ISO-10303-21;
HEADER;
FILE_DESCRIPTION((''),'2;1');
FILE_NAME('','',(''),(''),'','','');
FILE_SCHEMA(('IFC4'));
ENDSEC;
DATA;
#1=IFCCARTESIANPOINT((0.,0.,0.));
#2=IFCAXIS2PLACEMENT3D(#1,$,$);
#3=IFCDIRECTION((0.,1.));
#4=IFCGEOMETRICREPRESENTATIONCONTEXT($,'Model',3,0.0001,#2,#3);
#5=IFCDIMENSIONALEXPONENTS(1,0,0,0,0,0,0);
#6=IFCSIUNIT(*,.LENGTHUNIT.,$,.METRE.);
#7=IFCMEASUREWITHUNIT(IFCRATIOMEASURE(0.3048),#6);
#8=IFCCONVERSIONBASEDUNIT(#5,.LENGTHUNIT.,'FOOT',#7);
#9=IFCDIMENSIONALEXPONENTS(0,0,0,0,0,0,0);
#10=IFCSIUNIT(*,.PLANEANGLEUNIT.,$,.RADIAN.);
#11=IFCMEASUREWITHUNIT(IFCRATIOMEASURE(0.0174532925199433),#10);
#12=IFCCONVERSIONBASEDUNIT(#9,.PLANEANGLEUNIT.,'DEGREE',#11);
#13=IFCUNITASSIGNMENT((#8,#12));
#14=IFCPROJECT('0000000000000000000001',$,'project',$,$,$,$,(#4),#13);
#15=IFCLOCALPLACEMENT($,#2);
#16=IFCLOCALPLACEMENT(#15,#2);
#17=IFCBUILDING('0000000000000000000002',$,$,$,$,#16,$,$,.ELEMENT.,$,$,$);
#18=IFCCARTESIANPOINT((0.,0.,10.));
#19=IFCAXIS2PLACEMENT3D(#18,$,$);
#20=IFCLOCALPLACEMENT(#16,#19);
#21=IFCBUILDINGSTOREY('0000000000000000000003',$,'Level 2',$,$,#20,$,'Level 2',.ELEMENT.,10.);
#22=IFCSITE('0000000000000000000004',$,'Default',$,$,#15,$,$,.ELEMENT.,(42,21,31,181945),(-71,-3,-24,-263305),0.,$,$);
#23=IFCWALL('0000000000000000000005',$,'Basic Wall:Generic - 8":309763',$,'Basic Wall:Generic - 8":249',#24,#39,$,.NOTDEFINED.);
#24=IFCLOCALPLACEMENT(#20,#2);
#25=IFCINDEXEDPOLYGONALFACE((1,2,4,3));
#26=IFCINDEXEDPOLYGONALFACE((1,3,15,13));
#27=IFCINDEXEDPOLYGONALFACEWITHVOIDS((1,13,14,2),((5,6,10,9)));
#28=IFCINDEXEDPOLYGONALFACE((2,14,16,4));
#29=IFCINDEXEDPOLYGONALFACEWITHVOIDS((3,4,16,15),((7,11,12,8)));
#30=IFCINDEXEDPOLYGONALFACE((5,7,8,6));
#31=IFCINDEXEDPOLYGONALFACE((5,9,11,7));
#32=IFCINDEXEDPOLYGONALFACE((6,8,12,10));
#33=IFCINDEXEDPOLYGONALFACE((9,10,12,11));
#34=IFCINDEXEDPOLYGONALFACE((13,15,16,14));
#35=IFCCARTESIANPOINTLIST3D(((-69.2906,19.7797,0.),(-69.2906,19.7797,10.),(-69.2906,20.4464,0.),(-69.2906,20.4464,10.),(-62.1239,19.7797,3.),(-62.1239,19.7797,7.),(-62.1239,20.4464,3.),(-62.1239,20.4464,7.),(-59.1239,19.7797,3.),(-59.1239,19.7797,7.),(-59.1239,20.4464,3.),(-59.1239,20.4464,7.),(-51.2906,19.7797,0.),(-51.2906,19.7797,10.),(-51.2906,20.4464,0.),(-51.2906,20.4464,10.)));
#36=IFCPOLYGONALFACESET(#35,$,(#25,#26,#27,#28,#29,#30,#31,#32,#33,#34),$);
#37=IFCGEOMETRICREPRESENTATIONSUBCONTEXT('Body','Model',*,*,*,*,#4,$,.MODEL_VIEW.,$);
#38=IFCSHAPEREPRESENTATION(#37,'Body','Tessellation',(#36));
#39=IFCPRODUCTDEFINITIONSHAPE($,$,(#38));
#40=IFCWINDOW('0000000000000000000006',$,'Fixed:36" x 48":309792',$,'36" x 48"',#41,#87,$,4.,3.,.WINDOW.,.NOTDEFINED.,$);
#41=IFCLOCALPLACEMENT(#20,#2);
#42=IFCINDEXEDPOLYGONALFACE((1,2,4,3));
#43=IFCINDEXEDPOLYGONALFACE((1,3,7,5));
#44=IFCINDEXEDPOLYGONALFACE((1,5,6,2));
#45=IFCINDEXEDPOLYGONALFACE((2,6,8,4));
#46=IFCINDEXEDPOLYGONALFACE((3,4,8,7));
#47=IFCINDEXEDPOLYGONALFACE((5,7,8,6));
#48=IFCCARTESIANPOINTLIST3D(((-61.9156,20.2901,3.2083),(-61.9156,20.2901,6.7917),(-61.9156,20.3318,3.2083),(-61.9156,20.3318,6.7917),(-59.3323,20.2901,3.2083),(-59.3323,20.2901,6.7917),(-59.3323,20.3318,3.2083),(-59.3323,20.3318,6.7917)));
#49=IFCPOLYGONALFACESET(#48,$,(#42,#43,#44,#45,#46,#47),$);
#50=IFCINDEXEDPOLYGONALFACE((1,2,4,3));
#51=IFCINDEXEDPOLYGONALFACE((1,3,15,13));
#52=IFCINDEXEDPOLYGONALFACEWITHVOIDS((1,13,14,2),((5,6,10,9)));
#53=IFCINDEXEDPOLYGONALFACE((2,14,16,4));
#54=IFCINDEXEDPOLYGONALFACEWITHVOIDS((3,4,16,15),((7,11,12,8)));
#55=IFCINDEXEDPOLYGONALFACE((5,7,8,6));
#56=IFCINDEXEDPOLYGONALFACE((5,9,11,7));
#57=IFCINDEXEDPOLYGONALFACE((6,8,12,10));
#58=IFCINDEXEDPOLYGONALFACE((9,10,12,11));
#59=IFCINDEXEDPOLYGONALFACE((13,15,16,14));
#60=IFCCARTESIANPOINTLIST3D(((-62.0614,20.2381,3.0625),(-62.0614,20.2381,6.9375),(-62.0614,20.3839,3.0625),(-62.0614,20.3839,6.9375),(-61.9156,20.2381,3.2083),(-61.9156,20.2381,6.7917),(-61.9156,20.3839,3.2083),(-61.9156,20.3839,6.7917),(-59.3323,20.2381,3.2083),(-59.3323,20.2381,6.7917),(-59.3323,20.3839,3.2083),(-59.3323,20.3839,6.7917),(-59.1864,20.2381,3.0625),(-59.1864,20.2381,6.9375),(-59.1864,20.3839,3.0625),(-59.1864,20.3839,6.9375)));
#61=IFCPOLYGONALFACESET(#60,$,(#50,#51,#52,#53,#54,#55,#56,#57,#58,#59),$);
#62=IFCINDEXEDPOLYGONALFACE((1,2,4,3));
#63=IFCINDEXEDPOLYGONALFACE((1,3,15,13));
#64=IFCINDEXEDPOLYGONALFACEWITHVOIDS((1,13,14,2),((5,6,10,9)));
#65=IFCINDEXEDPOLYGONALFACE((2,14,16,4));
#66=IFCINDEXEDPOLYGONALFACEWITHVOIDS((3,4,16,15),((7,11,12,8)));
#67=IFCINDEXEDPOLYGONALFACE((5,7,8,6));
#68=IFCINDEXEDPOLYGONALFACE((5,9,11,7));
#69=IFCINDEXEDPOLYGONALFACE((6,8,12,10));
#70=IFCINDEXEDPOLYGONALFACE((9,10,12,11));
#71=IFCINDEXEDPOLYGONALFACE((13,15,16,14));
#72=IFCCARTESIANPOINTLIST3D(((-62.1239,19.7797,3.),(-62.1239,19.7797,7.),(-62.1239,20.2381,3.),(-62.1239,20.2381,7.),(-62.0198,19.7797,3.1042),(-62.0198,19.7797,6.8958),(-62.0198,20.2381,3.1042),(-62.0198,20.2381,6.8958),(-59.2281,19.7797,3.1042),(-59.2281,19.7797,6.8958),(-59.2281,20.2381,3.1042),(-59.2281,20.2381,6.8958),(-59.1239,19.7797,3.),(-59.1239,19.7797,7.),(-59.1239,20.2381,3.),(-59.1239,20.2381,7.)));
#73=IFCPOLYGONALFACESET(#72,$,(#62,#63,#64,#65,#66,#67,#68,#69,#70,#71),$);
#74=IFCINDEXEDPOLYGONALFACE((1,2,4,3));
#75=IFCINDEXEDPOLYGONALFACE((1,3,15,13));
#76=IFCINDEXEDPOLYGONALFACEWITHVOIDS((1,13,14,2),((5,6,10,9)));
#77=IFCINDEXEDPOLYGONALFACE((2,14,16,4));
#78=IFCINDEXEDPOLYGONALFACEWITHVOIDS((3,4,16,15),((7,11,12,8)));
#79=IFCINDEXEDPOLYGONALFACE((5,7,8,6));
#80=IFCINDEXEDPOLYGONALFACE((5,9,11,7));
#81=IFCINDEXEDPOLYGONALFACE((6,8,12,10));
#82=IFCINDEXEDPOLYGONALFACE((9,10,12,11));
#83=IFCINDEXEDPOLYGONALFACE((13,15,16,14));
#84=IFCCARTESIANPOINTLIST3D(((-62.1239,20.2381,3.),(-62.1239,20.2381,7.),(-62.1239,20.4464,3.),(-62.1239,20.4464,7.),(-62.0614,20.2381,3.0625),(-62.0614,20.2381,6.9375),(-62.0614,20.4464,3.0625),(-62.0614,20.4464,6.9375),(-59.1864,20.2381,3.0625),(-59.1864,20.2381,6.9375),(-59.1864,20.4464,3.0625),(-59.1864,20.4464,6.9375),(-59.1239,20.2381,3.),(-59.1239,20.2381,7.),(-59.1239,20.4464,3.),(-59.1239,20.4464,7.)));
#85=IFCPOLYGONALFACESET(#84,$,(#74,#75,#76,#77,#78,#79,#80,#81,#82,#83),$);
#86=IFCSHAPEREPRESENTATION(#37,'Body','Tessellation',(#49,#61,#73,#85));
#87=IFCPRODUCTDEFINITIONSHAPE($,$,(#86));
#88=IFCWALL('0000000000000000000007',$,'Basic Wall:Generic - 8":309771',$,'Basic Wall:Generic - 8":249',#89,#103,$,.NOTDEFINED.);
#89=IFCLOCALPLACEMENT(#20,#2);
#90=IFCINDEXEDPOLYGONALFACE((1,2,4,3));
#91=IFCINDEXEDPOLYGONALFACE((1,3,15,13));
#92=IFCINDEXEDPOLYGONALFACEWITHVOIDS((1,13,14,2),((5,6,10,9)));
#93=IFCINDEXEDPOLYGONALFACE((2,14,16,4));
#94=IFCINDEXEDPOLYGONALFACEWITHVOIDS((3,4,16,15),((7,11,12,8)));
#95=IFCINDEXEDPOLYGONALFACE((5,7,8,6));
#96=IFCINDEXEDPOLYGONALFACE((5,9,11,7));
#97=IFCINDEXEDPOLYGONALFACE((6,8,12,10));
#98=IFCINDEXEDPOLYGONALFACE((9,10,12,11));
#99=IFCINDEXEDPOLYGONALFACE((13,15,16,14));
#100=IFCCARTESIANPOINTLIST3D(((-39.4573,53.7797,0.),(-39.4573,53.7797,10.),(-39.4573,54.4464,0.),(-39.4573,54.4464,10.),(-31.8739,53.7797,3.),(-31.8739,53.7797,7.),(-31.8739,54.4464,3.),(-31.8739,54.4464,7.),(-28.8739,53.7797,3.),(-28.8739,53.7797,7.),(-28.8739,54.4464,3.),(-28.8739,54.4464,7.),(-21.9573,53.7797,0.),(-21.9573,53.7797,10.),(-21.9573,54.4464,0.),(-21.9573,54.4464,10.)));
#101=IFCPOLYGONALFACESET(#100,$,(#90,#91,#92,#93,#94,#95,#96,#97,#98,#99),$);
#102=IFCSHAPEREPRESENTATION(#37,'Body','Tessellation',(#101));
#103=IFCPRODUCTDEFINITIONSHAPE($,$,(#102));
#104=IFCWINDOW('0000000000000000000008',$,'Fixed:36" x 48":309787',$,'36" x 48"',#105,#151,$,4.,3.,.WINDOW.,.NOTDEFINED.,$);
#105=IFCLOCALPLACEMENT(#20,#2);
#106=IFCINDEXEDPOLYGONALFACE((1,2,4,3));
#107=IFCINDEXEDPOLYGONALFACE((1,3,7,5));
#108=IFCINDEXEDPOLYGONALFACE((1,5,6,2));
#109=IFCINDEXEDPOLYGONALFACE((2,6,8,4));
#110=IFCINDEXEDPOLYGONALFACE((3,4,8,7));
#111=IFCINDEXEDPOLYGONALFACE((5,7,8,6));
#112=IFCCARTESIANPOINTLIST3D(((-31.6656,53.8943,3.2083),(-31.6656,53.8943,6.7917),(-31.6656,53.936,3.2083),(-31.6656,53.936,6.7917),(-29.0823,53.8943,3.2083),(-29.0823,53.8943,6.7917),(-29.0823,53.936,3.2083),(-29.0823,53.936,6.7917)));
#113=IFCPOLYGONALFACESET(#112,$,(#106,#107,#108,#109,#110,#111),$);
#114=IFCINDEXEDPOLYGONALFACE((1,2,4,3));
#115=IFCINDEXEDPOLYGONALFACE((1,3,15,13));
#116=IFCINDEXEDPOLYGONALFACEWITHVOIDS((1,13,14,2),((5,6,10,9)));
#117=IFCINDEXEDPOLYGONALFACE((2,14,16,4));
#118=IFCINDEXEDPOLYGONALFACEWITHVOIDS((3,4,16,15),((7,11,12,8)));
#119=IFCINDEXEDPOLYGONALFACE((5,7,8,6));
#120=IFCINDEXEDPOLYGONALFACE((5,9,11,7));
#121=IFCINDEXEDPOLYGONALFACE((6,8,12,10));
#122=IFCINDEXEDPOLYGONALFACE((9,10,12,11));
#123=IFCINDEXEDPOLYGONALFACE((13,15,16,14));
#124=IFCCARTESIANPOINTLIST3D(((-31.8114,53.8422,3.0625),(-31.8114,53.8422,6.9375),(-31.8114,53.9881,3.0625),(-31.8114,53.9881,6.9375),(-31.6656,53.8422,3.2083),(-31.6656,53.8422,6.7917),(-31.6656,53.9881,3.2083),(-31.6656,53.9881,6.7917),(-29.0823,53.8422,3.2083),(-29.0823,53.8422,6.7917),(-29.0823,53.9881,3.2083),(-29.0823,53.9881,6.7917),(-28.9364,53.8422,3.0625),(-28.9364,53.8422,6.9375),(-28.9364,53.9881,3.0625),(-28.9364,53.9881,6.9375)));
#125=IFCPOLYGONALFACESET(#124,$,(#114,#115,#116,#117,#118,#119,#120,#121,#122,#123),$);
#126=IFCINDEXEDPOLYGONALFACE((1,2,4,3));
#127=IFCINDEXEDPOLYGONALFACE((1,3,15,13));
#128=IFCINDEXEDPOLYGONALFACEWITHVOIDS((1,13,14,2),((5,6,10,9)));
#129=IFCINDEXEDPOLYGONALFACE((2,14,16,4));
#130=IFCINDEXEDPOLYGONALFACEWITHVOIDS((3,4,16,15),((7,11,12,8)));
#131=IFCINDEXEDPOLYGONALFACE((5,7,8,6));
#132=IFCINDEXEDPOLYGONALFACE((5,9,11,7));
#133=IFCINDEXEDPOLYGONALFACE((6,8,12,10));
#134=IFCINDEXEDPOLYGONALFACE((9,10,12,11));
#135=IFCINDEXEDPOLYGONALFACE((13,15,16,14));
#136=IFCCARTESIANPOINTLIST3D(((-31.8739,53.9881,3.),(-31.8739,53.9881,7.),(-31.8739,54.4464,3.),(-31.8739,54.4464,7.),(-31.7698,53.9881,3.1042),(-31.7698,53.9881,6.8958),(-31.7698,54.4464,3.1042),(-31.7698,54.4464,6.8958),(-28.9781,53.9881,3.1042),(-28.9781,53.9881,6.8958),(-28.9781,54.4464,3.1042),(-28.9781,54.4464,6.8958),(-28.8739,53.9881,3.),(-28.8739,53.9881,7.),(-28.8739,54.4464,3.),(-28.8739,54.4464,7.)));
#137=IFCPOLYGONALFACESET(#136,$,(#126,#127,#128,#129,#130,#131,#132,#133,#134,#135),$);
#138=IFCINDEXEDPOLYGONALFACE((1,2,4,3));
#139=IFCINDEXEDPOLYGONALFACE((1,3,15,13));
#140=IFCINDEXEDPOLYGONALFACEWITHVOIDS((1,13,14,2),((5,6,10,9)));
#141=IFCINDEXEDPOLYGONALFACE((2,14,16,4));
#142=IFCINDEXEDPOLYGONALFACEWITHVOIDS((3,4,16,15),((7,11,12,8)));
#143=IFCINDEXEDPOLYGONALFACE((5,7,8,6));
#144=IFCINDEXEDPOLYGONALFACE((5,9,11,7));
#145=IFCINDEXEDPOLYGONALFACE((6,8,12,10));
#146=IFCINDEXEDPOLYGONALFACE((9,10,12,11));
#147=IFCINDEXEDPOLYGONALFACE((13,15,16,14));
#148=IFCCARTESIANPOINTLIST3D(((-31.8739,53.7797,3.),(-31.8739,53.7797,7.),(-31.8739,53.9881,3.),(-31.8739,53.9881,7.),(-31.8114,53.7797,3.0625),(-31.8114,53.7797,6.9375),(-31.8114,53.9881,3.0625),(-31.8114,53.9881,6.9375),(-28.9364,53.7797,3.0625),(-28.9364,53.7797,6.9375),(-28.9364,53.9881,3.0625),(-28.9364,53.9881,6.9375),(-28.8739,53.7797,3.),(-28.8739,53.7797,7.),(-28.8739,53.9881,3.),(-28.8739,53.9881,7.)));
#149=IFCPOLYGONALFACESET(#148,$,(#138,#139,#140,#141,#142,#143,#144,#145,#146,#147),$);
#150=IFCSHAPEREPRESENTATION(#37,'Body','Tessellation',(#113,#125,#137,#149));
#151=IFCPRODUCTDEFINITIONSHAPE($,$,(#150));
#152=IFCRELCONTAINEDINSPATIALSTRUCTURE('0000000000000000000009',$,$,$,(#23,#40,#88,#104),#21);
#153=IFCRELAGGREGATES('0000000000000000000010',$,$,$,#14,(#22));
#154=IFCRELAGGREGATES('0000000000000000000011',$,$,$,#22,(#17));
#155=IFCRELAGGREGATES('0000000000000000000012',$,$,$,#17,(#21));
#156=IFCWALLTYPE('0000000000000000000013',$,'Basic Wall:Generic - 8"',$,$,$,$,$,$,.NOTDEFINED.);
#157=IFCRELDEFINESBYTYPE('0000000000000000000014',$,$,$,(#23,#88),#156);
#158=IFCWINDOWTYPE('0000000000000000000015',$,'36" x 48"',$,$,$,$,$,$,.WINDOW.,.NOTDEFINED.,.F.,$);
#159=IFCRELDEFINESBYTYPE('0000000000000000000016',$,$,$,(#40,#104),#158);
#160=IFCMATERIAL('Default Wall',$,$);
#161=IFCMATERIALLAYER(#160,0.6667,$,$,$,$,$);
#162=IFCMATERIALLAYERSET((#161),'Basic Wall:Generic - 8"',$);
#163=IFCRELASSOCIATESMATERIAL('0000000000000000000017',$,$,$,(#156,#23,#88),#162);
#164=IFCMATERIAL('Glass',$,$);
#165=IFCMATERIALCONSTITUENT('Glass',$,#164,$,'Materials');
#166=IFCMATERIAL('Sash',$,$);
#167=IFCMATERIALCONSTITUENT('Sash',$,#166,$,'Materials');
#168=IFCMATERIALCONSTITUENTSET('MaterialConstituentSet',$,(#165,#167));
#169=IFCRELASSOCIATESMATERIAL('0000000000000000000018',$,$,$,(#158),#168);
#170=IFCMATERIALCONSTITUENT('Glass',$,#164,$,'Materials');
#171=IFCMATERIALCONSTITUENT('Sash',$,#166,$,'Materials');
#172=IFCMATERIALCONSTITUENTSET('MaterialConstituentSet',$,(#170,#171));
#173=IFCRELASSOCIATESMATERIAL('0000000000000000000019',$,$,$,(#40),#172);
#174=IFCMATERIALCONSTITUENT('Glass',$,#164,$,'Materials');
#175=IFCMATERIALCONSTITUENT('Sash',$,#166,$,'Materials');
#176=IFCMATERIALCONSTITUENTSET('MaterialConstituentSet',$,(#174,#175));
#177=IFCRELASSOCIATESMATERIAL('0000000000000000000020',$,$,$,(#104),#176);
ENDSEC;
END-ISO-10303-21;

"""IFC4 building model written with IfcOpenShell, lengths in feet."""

from ifc_helpers import new_model, entity, si_unit, converted_unit, direction, frame, frame_2d, origin, place, context, subcontext, project, spatial, polyline, rectangle, outline, extrude, source, transform, mapped, material, layer, layer_set, layer_usage, constituent, constituent_set, type_object, type_shapes, element, fill, save


model = new_model("IFC4")

# Units and contexts
model_context = context("Model", 3, precision=0.0001, world=origin(), true_north=direction((0.0, 1.0)))
body_context = subcontext(model_context, "Body", "Model", "MODEL_VIEW")
ifc_project = project(units=[converted_unit("LENGTHUNIT", "FOOT", entity("IfcRatioMeasure", 0.3048), si_unit("LENGTHUNIT", "METRE"), dimensions=[1, 0, 0, 0, 0, 0, 0]), converted_unit("PLANEANGLEUNIT", "DEGREE", entity("IfcRatioMeasure", 0.0174532925199433), si_unit("PLANEANGLEUNIT", "RADIAN"), dimensions=[0, 0, 0, 0, 0, 0, 0])], contexts=[model_context])

# Site, building, storey
site_placement = place(None, origin())
site = spatial("IfcSite", under=ifc_project, at=site_placement, Name="Default", CompositionType="ELEMENT", RefLatitude=(42, 21, 31, 181945), RefLongitude=(-71, -3, -24, -263305), RefElevation=0.0)
building_placement = place(site_placement, origin())
building = spatial("IfcBuilding", under=site, at=building_placement, CompositionType="ELEMENT")
storey_placement = place(building_placement, frame((0.0, 0.0, 10.0)))
storey = spatial("IfcBuildingStorey", under=building, at=storey_placement, Name="Level 2", LongName="Level 2", CompositionType="ELEMENT", Elevation=10.0)

# Shared definitions
ifc_material_1 = material(Name="Default Wall")
ifc_layer = layer(ifc_material_1, 0.6667)
ifc_layer_set = layer_set([ifc_layer], Name="Basic Wall:Generic - 8\"")
wall_type = type_object("IfcWallType", Name="Basic Wall:Generic - 8\"", PredefinedType="NOTDEFINED", material=ifc_layer_set)
ifc_material_2 = material(Name="Glass")
ifc_material_3 = material(Name="Sash")
ifc_constituent_1 = constituent(ifc_material_2, Name="Glass", Category="Materials")
ifc_constituent_2 = constituent(ifc_material_3, Name="Sash", Category="Materials")
ifc_constituent_set_1 = constituent_set(constituents=[ifc_constituent_1, ifc_constituent_2], Name="MaterialConstituentSet")
window_type_1 = type_object("IfcWindowType", Name="36\" x 48\"", ParameterTakesPrecedence=False, PartitioningType="NOTDEFINED", PredefinedType="WINDOW", material=ifc_constituent_set_1)
shared_shape_1 = source(origin(), body_context, "Body", "SweptSolid", [
    extrude(rectangle(XDim=0.0417, YDim=2.5833, at=frame_2d((0.0, 0.0), x_axis=(1.0, 0.0))), frame((1.5, 0.5312, 0.2083), z_axis=(0.0, 0.0, 1.0), x_axis=(0.0, 1.0, 0.0)), (0.0, 0.0, 1.0), 3.5833),
    extrude(outline(polyline([(-1.4375, -1.9375), (1.4375, -1.9375), (1.4375, 1.9375), (-1.4375, 1.9375), (-1.4375, -1.9375)]), holes=[polyline([(-1.2917, -1.7917), (-1.2917, 1.7917), (1.2917, 1.7917), (1.2917, -1.7917), (-1.2917, -1.7917)])]), frame((1.5, 0.4583, 2.0), z_axis=(0.0, 1.0, 0.0), x_axis=(1.0, 0.0, 0.0)), (0.0, 0.0, 1.0), 0.1458),
    extrude(outline(polyline([(-1.5, -2.0), (1.5, -2.0), (1.5, 2.0), (-1.5, 2.0), (-1.5, -2.0)]), holes=[polyline([(-1.3958, -1.8958), (-1.3958, 1.8958), (1.3958, 1.8958), (1.3958, -1.8958), (-1.3958, -1.8958)])]), frame((1.5, 0.0, 2.0), z_axis=(0.0, 1.0, 0.0), x_axis=(1.0, 0.0, 0.0)), (0.0, 0.0, 1.0), 0.4583),
    extrude(outline(polyline([(-2.0, -1.5), (2.0, -1.5), (2.0, 1.5), (-2.0, 1.5), (-2.0, -1.5)]), holes=[polyline([(-1.9375, -1.4375), (-1.9375, 1.4375), (1.9375, 1.4375), (1.9375, -1.4375), (-1.9375, -1.4375)])]), frame((1.5, 0.4583, 2.0), z_axis=(0.0, 1.0, 0.0), x_axis=(0.0, 0.0, -1.0)), (0.0, 0.0, 1.0), 0.2083),
])
type_shapes(window_type_1, [shared_shape_1])

# Walls, openings, windows
ifc_layer_usage_1 = layer_usage(ifc_layer_set, "AXIS2", "NEGATIVE", 0.3333)
wall_1_placement = place(storey_placement, frame((-69.2906, 20.1131, 0.0)))
wall_1 = element("IfcWall", 1, at=wall_1_placement, inside=storey, type_object=wall_type, material=ifc_layer_usage_1, Name="Basic Wall:Generic - 8\":309763", ObjectType="Basic Wall:Generic - 8\":249", PredefinedType="NOTDEFINED", context=body_context, shape_type="SweptSolid", body=[
    extrude(rectangle(XDim=18.0, YDim=0.6667, at=frame_2d((9.0, 0.0), x_axis=(-1.0, 0.0))), origin(), (0.0, 0.0, 1.0), 10.0),
])
opening_1_placement = place(wall_1_placement, frame((7.1667, -0.3333, 3.0)))
opening_1 = element("IfcOpeningElement", 2, at=opening_1_placement, cuts=wall_1, ObjectType="Opening", PredefinedType="OPENING", context=body_context, shape_type="SweptSolid", body=[
    extrude(rectangle(XDim=4.0, YDim=3.0, at=frame_2d((2.0, 1.5), x_axis=(-1.0, 0.0))), frame((0.0, 0.0, 0.0), z_axis=(0.0, 1.0, 0.0), x_axis=(0.0, 0.0, 1.0)), (0.0, 0.0, 1.0), 0.6667),
])
ifc_constituent_3 = constituent(ifc_material_2, Name="Glass", Category="Materials")
ifc_constituent_4 = constituent(ifc_material_3, Name="Sash", Category="Materials")
ifc_constituent_set_2 = constituent_set(constituents=[ifc_constituent_3, ifc_constituent_4], Name="MaterialConstituentSet")
window_1_placement = place(opening_1_placement, origin())
window_1 = element("IfcWindow", 3, at=window_1_placement, inside=storey, type_object=window_type_1, material=ifc_constituent_set_2, Name="Fixed:36\" x 48\":309792", ObjectType="36\" x 48\"", OverallHeight=4.0, OverallWidth=3.0, PartitioningType="NOTDEFINED", PredefinedType="WINDOW", context=body_context, shape_type="MappedRepresentation", body=[
    mapped(shared_shape_1, transform((0.0, 0.0, 0.0), scale=1.0)),
])
fill(opening_1, window_1)
ifc_layer_usage_2 = layer_usage(ifc_layer_set, "AXIS2", "NEGATIVE", 0.3333)
wall_2_placement = place(storey_placement, frame((-39.4573, 54.1131, 0.0)))
wall_2 = element("IfcWall", 4, at=wall_2_placement, inside=storey, type_object=wall_type, material=ifc_layer_usage_2, Name="Basic Wall:Generic - 8\":309771", ObjectType="Basic Wall:Generic - 8\":249", PredefinedType="NOTDEFINED", context=body_context, shape_type="SweptSolid", body=[
    extrude(rectangle(XDim=17.5, YDim=0.6667, at=frame_2d((8.75, 0.0), x_axis=(-1.0, 0.0))), origin(), (0.0, 0.0, 1.0), 10.0),
])
opening_2_placement = place(wall_2_placement, frame((10.5833, 0.3333, 3.0)))
opening_2 = element("IfcOpeningElement", 5, at=opening_2_placement, cuts=wall_2, ObjectType="Opening", PredefinedType="OPENING", context=body_context, shape_type="SweptSolid", body=[
    extrude(rectangle(XDim=4.0, YDim=3.0, at=frame_2d((2.0, 1.5), x_axis=(-1.0, 0.0))), frame((0.0, 0.0, 0.0), z_axis=(0.0, -1.0, 0.0), x_axis=(0.0, 0.0, 1.0)), (0.0, 0.0, 1.0), 0.6667),
])
ifc_constituent_5 = constituent(ifc_material_2, Name="Glass", Category="Materials")
ifc_constituent_6 = constituent(ifc_material_3, Name="Sash", Category="Materials")
ifc_constituent_set_3 = constituent_set(constituents=[ifc_constituent_5, ifc_constituent_6], Name="MaterialConstituentSet")
window_2_placement = place(opening_2_placement, frame((0.0, 0.0, 0.0), z_axis=(0.0, 0.0, 1.0), x_axis=(-1.0, 0.0, 0.0)))
window_2 = element("IfcWindow", 6, at=window_2_placement, inside=storey, type_object=window_type_1, material=ifc_constituent_set_3, Name="Fixed:36\" x 48\":309787", ObjectType="36\" x 48\"", OverallHeight=4.0, OverallWidth=3.0, PartitioningType="NOTDEFINED", PredefinedType="WINDOW", context=body_context, shape_type="MappedRepresentation", body=[
    mapped(shared_shape_1, transform((0.0, 0.0, 0.0), scale=1.0)),
])
fill(opening_2, window_2)

save(model, "model.ifc")
